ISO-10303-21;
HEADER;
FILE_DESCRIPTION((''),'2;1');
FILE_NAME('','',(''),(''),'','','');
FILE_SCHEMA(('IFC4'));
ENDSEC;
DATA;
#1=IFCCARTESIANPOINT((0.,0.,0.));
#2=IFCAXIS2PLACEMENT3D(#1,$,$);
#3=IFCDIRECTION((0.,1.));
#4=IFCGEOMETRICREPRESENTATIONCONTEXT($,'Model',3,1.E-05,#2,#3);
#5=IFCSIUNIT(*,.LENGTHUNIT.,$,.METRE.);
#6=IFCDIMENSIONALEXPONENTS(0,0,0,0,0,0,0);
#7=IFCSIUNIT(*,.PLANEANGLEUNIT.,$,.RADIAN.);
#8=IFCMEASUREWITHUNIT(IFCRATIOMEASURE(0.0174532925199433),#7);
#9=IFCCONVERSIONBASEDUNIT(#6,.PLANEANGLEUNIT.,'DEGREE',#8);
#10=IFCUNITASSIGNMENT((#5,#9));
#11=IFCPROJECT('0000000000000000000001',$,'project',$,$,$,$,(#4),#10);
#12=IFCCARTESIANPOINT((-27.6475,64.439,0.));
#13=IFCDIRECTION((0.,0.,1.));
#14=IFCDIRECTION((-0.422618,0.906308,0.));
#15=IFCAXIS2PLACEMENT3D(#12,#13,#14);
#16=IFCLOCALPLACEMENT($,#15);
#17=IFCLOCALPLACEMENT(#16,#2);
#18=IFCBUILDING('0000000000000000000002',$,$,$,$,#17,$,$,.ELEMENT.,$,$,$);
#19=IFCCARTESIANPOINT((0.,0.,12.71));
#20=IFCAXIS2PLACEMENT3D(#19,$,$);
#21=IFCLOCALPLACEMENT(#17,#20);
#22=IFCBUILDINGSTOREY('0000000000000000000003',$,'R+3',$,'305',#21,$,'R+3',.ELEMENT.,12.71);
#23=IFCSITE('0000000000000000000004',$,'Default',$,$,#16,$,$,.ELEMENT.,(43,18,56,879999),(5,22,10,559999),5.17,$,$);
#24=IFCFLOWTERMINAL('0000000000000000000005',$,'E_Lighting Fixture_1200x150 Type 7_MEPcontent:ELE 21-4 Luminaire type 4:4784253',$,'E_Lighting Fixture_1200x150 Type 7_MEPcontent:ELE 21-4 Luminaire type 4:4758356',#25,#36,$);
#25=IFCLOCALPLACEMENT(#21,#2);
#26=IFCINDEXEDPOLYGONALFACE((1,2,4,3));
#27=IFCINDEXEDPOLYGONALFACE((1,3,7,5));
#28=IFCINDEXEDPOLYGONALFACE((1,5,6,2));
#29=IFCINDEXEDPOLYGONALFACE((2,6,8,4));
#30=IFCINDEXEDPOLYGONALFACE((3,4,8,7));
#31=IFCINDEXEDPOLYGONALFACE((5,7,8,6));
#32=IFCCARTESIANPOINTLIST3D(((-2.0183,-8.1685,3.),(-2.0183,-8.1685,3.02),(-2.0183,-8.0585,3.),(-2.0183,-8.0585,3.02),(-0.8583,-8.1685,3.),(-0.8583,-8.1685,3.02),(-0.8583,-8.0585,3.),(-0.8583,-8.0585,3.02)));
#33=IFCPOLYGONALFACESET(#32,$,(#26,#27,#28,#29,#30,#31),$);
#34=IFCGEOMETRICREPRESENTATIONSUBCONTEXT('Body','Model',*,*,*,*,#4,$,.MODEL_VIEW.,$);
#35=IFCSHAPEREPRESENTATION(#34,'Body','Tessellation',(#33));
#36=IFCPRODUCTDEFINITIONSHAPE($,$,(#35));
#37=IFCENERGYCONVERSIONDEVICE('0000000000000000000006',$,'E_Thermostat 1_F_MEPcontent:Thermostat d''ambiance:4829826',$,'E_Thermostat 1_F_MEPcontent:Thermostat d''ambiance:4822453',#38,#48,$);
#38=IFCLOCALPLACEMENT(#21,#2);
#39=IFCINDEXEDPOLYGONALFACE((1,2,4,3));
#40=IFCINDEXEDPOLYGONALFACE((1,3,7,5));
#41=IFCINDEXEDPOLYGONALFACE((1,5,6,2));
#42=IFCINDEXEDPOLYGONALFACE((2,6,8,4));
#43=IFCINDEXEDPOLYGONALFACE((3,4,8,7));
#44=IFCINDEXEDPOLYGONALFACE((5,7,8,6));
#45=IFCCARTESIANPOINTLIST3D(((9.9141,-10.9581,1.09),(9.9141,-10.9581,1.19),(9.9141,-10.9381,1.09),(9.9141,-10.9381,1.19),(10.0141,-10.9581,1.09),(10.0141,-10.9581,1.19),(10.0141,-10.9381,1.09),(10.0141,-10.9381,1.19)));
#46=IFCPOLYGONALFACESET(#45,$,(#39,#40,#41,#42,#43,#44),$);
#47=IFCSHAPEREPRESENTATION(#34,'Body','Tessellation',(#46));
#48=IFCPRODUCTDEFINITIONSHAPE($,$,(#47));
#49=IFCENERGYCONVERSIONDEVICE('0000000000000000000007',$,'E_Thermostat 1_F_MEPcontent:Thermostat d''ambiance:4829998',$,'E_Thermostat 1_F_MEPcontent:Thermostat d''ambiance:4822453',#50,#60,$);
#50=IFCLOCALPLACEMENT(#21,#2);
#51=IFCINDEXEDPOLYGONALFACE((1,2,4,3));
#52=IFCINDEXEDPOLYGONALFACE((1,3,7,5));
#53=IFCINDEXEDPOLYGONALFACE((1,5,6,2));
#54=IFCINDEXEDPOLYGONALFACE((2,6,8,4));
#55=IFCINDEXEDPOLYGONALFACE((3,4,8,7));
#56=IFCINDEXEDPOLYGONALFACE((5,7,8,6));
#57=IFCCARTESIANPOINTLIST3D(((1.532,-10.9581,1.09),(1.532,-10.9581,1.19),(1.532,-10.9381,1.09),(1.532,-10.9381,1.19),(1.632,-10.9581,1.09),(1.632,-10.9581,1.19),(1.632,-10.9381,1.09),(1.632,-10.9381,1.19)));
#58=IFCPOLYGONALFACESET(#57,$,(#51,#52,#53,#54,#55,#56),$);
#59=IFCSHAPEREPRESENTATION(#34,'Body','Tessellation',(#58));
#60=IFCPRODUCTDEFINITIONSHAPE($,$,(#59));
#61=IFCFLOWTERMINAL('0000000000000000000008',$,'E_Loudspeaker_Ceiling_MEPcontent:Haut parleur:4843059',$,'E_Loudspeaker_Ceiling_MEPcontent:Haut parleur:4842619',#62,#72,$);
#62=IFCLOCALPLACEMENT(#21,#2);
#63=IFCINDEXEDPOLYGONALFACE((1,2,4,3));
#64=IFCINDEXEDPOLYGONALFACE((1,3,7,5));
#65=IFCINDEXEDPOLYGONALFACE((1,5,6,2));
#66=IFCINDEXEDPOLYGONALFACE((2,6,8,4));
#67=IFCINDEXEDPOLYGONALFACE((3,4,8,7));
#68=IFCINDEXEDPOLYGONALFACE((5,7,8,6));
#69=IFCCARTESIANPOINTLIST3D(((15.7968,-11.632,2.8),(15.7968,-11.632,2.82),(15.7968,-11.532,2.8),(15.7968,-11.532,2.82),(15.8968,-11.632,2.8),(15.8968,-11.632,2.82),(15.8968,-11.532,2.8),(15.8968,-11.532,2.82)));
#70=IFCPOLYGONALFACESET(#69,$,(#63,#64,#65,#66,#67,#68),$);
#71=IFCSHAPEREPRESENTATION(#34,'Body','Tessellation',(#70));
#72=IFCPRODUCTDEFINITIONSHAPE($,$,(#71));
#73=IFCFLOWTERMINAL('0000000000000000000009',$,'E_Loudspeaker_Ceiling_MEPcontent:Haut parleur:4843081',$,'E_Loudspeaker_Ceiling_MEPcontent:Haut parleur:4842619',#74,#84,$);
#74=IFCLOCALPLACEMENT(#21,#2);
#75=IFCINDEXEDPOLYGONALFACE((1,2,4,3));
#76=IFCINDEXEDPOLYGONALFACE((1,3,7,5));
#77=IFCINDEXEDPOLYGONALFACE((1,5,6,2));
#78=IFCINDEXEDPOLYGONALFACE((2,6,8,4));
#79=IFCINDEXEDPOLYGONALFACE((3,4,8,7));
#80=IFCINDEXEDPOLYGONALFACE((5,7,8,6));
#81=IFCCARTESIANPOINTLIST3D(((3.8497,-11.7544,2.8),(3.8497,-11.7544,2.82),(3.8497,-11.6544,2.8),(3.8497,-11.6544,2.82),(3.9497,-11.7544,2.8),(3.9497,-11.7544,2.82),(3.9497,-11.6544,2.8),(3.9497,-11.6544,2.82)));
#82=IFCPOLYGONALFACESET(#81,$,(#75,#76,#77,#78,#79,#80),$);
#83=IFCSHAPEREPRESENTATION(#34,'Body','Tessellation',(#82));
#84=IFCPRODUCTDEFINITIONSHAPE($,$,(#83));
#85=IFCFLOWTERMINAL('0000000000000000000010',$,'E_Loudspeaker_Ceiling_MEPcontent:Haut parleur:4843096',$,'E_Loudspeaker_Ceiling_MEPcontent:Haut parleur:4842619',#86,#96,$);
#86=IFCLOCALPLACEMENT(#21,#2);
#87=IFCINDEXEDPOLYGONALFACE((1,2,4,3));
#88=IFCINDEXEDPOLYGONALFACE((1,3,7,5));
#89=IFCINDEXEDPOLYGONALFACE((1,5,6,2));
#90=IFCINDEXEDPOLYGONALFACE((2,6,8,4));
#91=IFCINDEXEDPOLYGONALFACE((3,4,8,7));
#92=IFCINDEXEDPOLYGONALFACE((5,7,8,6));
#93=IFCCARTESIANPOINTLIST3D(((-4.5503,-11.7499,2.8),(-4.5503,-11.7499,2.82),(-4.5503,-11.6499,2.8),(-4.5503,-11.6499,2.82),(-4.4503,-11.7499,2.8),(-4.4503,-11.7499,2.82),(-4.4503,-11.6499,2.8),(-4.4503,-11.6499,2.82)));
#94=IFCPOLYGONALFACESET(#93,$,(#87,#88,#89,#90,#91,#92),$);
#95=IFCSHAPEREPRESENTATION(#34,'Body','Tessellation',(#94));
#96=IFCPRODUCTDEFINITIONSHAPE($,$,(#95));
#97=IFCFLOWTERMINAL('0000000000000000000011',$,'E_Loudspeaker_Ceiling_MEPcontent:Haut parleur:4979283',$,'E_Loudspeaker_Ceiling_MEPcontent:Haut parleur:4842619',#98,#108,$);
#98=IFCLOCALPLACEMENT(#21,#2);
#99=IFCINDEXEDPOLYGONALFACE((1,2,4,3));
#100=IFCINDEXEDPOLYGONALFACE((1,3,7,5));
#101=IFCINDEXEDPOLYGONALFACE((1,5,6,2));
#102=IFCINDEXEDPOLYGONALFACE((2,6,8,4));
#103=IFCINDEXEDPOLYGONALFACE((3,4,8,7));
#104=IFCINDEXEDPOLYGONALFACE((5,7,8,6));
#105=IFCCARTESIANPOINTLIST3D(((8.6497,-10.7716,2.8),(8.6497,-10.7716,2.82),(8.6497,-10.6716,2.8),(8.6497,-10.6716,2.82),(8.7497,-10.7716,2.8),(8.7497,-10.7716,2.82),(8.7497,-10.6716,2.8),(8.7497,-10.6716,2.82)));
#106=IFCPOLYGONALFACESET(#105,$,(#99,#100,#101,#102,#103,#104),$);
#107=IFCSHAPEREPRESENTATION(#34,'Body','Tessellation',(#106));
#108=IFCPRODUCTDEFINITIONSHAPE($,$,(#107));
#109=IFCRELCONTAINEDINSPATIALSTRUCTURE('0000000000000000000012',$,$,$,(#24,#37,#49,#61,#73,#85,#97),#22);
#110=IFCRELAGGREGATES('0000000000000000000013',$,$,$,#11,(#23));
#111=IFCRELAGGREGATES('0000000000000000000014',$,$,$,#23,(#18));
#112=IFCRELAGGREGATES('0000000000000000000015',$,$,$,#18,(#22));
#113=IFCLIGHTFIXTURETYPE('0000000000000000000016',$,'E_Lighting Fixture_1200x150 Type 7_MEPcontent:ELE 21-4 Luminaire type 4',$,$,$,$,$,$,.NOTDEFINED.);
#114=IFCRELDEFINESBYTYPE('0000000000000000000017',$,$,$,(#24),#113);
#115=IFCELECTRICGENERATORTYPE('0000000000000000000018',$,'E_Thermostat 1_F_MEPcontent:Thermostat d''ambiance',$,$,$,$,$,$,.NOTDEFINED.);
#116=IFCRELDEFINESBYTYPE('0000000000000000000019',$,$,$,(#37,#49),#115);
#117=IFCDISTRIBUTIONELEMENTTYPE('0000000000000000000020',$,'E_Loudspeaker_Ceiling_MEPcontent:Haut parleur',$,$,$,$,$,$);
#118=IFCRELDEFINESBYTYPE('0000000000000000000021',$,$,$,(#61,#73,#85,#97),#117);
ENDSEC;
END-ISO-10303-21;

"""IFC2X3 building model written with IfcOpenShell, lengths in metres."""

from ifc_helpers import new_model, entity, si_unit, converted_unit, direction, frame, origin, origin_2d_with_axis, place, context, subcontext, project, spatial, rectangle, extrude, source, transform, mapped, type_object, type_shapes, element, save


model = new_model("IFC2X3")

# Units and contexts
model_context = context("Model", 3, precision=1e-05, world=origin(), true_north=direction((0.0, 1.0)))
body_context = subcontext(model_context, "Body", "Model", "MODEL_VIEW")
ifc_project = project(units=[si_unit("LENGTHUNIT", "METRE"), converted_unit("PLANEANGLEUNIT", "DEGREE", entity("IfcRatioMeasure", 0.0174532925199433), si_unit("PLANEANGLEUNIT", "RADIAN"), dimensions=[0, 0, 0, 0, 0, 0, 0])], contexts=[model_context])

# Site, building, storey
site_placement = place(None, frame((-27.6475, 64.439, 0.0), z_axis=(0.0, 0.0, 1.0), x_axis=(-0.422618, 0.906308, 0.0)))
site = spatial("IfcSite", under=ifc_project, at=site_placement, Name="Default", CompositionType="ELEMENT", RefLatitude=(43, 18, 56, 879999), RefLongitude=(5, 22, 10, 559999), RefElevation=5.17)
building_placement = place(site_placement, origin())
building = spatial("IfcBuilding", under=site, at=building_placement, CompositionType="ELEMENT")
storey_placement = place(building_placement, frame((0.0, 0.0, 12.71)))
storey = spatial("IfcBuildingStorey", under=building, at=storey_placement, Name="R+3", ObjectType="305", LongName="R+3", CompositionType="ELEMENT", Elevation=12.71)

# Flow terminal
light_fixture_type = type_object("IfcLightFixtureType", Name="E_Lighting Fixture_1200x150 Type 7_MEPcontent:ELE 21-4 Luminaire type 4", PredefinedType="NOTDEFINED")
shared_shape_1 = source(origin(), body_context, "Body", "SweptSolid", [
    extrude(rectangle(XDim=0.11, YDim=1.16, at=origin_2d_with_axis()), frame((0.0, 0.0, 0.0), z_axis=(0.0, 0.0, 1.0), x_axis=(0.0, -1.0, 0.0)), (0.0, 0.0, 1.0), 0.02),
])
type_shapes(light_fixture_type, [shared_shape_1])
for number, where, name in (
    (1, (-1.4383, -8.1135, 3.0), "E_Lighting Fixture_1200x150 Type 7_MEPcontent:ELE 21-4 Luminaire type 4:4784253"),
):
    element("IfcFlowTerminal", number, at=place(storey_placement, frame(where)), inside=storey, type_object=light_fixture_type, Name=name, ObjectType="E_Lighting Fixture_1200x150 Type 7_MEPcontent:ELE 21-4 Luminaire type 4:4758356", context=body_context, shape_type="MappedRepresentation", body=[
        mapped(shared_shape_1, transform((0.0, 0.0, 0.0), scale=1.0)),
    ])

# Energy conversion devices
electric_generator_type = type_object("IfcElectricGeneratorType", Name="E_Thermostat 1_F_MEPcontent:Thermostat d'ambiance", PredefinedType="NOTDEFINED")
shared_shape_2 = source(origin(), body_context, "Body", "SweptSolid", [
    extrude(rectangle(XDim=0.1, YDim=0.1, at=origin_2d_with_axis()), frame((0.0, 0.0, 0.0), z_axis=(0.0, 0.0, 1.0), x_axis=(0.0, 1.0, 0.0)), (0.0, 0.0, 1.0), 0.02),
])
type_shapes(electric_generator_type, [shared_shape_2])
for number, where, z_axis, x_axis, name in (
    (2, (9.9641, -10.9381, 1.14), (0.0, -1.0, 0.0), (1.0, 0.0, 0.0), "E_Thermostat 1_F_MEPcontent:Thermostat d'ambiance:4829826"),
    (3, (1.582, -10.9381, 1.14), (0.0, -1.0, 0.0), (1.0, 0.0, 0.0), "E_Thermostat 1_F_MEPcontent:Thermostat d'ambiance:4829998"),
):
    element("IfcEnergyConversionDevice", number, at=place(storey_placement, frame(where, z_axis=z_axis, x_axis=x_axis)), inside=storey, type_object=electric_generator_type, Name=name, ObjectType="E_Thermostat 1_F_MEPcontent:Thermostat d'ambiance:4822453", context=body_context, shape_type="MappedRepresentation", body=[
        mapped(shared_shape_2, transform((0.0, 0.0, 0.0), scale=1.0)),
    ])

# Flow terminals
distribution_element_type = type_object("IfcDistributionElementType", Name="E_Loudspeaker_Ceiling_MEPcontent:Haut parleur")
shared_shape_3 = source(origin(), body_context, "Body", "SweptSolid", [
    extrude(rectangle(XDim=0.1, YDim=0.1, at=origin_2d_with_axis()), frame((0.0, 0.0, 0.0), z_axis=(0.0, 0.0, 1.0), x_axis=(0.0, -1.0, 0.0)), (0.0, 0.0, 1.0), 0.02),
])
type_shapes(distribution_element_type, [shared_shape_3])
for number, where, z_axis, x_axis, name in (
    (4, (15.8468, -11.582, 2.8), (0.0, 0.0, 1.0), (-1.0, 0.0, 0.0), "E_Loudspeaker_Ceiling_MEPcontent:Haut parleur:4843059"),
    (5, (3.8997, -11.7044, 2.8), (0.0, 0.0, 1.0), (-1.0, 0.0, 0.0), "E_Loudspeaker_Ceiling_MEPcontent:Haut parleur:4843081"),
    (6, (-4.5003, -11.6999, 2.8), (0.0, 0.0, 1.0), (-1.0, 0.0, 0.0), "E_Loudspeaker_Ceiling_MEPcontent:Haut parleur:4843096"),
):
    element("IfcFlowTerminal", number, at=place(storey_placement, frame(where, z_axis=z_axis, x_axis=x_axis)), inside=storey, type_object=distribution_element_type, Name=name, ObjectType="E_Loudspeaker_Ceiling_MEPcontent:Haut parleur:4842619", context=body_context, shape_type="MappedRepresentation", body=[
        mapped(shared_shape_3, transform((0.0, 0.0, 0.0), scale=1.0)),
    ])
flow_terminal_placement = place(storey_placement, frame((8.6997, -10.7216, 2.8)))
element("IfcFlowTerminal", 7, at=flow_terminal_placement, inside=storey, type_object=distribution_element_type, Name="E_Loudspeaker_Ceiling_MEPcontent:Haut parleur:4979283", ObjectType="E_Loudspeaker_Ceiling_MEPcontent:Haut parleur:4842619", context=body_context, shape_type="MappedRepresentation", body=[
    mapped(shared_shape_3, transform((0.0, 0.0, 0.0), scale=1.0)),
])

save(model, "model.ifc")
